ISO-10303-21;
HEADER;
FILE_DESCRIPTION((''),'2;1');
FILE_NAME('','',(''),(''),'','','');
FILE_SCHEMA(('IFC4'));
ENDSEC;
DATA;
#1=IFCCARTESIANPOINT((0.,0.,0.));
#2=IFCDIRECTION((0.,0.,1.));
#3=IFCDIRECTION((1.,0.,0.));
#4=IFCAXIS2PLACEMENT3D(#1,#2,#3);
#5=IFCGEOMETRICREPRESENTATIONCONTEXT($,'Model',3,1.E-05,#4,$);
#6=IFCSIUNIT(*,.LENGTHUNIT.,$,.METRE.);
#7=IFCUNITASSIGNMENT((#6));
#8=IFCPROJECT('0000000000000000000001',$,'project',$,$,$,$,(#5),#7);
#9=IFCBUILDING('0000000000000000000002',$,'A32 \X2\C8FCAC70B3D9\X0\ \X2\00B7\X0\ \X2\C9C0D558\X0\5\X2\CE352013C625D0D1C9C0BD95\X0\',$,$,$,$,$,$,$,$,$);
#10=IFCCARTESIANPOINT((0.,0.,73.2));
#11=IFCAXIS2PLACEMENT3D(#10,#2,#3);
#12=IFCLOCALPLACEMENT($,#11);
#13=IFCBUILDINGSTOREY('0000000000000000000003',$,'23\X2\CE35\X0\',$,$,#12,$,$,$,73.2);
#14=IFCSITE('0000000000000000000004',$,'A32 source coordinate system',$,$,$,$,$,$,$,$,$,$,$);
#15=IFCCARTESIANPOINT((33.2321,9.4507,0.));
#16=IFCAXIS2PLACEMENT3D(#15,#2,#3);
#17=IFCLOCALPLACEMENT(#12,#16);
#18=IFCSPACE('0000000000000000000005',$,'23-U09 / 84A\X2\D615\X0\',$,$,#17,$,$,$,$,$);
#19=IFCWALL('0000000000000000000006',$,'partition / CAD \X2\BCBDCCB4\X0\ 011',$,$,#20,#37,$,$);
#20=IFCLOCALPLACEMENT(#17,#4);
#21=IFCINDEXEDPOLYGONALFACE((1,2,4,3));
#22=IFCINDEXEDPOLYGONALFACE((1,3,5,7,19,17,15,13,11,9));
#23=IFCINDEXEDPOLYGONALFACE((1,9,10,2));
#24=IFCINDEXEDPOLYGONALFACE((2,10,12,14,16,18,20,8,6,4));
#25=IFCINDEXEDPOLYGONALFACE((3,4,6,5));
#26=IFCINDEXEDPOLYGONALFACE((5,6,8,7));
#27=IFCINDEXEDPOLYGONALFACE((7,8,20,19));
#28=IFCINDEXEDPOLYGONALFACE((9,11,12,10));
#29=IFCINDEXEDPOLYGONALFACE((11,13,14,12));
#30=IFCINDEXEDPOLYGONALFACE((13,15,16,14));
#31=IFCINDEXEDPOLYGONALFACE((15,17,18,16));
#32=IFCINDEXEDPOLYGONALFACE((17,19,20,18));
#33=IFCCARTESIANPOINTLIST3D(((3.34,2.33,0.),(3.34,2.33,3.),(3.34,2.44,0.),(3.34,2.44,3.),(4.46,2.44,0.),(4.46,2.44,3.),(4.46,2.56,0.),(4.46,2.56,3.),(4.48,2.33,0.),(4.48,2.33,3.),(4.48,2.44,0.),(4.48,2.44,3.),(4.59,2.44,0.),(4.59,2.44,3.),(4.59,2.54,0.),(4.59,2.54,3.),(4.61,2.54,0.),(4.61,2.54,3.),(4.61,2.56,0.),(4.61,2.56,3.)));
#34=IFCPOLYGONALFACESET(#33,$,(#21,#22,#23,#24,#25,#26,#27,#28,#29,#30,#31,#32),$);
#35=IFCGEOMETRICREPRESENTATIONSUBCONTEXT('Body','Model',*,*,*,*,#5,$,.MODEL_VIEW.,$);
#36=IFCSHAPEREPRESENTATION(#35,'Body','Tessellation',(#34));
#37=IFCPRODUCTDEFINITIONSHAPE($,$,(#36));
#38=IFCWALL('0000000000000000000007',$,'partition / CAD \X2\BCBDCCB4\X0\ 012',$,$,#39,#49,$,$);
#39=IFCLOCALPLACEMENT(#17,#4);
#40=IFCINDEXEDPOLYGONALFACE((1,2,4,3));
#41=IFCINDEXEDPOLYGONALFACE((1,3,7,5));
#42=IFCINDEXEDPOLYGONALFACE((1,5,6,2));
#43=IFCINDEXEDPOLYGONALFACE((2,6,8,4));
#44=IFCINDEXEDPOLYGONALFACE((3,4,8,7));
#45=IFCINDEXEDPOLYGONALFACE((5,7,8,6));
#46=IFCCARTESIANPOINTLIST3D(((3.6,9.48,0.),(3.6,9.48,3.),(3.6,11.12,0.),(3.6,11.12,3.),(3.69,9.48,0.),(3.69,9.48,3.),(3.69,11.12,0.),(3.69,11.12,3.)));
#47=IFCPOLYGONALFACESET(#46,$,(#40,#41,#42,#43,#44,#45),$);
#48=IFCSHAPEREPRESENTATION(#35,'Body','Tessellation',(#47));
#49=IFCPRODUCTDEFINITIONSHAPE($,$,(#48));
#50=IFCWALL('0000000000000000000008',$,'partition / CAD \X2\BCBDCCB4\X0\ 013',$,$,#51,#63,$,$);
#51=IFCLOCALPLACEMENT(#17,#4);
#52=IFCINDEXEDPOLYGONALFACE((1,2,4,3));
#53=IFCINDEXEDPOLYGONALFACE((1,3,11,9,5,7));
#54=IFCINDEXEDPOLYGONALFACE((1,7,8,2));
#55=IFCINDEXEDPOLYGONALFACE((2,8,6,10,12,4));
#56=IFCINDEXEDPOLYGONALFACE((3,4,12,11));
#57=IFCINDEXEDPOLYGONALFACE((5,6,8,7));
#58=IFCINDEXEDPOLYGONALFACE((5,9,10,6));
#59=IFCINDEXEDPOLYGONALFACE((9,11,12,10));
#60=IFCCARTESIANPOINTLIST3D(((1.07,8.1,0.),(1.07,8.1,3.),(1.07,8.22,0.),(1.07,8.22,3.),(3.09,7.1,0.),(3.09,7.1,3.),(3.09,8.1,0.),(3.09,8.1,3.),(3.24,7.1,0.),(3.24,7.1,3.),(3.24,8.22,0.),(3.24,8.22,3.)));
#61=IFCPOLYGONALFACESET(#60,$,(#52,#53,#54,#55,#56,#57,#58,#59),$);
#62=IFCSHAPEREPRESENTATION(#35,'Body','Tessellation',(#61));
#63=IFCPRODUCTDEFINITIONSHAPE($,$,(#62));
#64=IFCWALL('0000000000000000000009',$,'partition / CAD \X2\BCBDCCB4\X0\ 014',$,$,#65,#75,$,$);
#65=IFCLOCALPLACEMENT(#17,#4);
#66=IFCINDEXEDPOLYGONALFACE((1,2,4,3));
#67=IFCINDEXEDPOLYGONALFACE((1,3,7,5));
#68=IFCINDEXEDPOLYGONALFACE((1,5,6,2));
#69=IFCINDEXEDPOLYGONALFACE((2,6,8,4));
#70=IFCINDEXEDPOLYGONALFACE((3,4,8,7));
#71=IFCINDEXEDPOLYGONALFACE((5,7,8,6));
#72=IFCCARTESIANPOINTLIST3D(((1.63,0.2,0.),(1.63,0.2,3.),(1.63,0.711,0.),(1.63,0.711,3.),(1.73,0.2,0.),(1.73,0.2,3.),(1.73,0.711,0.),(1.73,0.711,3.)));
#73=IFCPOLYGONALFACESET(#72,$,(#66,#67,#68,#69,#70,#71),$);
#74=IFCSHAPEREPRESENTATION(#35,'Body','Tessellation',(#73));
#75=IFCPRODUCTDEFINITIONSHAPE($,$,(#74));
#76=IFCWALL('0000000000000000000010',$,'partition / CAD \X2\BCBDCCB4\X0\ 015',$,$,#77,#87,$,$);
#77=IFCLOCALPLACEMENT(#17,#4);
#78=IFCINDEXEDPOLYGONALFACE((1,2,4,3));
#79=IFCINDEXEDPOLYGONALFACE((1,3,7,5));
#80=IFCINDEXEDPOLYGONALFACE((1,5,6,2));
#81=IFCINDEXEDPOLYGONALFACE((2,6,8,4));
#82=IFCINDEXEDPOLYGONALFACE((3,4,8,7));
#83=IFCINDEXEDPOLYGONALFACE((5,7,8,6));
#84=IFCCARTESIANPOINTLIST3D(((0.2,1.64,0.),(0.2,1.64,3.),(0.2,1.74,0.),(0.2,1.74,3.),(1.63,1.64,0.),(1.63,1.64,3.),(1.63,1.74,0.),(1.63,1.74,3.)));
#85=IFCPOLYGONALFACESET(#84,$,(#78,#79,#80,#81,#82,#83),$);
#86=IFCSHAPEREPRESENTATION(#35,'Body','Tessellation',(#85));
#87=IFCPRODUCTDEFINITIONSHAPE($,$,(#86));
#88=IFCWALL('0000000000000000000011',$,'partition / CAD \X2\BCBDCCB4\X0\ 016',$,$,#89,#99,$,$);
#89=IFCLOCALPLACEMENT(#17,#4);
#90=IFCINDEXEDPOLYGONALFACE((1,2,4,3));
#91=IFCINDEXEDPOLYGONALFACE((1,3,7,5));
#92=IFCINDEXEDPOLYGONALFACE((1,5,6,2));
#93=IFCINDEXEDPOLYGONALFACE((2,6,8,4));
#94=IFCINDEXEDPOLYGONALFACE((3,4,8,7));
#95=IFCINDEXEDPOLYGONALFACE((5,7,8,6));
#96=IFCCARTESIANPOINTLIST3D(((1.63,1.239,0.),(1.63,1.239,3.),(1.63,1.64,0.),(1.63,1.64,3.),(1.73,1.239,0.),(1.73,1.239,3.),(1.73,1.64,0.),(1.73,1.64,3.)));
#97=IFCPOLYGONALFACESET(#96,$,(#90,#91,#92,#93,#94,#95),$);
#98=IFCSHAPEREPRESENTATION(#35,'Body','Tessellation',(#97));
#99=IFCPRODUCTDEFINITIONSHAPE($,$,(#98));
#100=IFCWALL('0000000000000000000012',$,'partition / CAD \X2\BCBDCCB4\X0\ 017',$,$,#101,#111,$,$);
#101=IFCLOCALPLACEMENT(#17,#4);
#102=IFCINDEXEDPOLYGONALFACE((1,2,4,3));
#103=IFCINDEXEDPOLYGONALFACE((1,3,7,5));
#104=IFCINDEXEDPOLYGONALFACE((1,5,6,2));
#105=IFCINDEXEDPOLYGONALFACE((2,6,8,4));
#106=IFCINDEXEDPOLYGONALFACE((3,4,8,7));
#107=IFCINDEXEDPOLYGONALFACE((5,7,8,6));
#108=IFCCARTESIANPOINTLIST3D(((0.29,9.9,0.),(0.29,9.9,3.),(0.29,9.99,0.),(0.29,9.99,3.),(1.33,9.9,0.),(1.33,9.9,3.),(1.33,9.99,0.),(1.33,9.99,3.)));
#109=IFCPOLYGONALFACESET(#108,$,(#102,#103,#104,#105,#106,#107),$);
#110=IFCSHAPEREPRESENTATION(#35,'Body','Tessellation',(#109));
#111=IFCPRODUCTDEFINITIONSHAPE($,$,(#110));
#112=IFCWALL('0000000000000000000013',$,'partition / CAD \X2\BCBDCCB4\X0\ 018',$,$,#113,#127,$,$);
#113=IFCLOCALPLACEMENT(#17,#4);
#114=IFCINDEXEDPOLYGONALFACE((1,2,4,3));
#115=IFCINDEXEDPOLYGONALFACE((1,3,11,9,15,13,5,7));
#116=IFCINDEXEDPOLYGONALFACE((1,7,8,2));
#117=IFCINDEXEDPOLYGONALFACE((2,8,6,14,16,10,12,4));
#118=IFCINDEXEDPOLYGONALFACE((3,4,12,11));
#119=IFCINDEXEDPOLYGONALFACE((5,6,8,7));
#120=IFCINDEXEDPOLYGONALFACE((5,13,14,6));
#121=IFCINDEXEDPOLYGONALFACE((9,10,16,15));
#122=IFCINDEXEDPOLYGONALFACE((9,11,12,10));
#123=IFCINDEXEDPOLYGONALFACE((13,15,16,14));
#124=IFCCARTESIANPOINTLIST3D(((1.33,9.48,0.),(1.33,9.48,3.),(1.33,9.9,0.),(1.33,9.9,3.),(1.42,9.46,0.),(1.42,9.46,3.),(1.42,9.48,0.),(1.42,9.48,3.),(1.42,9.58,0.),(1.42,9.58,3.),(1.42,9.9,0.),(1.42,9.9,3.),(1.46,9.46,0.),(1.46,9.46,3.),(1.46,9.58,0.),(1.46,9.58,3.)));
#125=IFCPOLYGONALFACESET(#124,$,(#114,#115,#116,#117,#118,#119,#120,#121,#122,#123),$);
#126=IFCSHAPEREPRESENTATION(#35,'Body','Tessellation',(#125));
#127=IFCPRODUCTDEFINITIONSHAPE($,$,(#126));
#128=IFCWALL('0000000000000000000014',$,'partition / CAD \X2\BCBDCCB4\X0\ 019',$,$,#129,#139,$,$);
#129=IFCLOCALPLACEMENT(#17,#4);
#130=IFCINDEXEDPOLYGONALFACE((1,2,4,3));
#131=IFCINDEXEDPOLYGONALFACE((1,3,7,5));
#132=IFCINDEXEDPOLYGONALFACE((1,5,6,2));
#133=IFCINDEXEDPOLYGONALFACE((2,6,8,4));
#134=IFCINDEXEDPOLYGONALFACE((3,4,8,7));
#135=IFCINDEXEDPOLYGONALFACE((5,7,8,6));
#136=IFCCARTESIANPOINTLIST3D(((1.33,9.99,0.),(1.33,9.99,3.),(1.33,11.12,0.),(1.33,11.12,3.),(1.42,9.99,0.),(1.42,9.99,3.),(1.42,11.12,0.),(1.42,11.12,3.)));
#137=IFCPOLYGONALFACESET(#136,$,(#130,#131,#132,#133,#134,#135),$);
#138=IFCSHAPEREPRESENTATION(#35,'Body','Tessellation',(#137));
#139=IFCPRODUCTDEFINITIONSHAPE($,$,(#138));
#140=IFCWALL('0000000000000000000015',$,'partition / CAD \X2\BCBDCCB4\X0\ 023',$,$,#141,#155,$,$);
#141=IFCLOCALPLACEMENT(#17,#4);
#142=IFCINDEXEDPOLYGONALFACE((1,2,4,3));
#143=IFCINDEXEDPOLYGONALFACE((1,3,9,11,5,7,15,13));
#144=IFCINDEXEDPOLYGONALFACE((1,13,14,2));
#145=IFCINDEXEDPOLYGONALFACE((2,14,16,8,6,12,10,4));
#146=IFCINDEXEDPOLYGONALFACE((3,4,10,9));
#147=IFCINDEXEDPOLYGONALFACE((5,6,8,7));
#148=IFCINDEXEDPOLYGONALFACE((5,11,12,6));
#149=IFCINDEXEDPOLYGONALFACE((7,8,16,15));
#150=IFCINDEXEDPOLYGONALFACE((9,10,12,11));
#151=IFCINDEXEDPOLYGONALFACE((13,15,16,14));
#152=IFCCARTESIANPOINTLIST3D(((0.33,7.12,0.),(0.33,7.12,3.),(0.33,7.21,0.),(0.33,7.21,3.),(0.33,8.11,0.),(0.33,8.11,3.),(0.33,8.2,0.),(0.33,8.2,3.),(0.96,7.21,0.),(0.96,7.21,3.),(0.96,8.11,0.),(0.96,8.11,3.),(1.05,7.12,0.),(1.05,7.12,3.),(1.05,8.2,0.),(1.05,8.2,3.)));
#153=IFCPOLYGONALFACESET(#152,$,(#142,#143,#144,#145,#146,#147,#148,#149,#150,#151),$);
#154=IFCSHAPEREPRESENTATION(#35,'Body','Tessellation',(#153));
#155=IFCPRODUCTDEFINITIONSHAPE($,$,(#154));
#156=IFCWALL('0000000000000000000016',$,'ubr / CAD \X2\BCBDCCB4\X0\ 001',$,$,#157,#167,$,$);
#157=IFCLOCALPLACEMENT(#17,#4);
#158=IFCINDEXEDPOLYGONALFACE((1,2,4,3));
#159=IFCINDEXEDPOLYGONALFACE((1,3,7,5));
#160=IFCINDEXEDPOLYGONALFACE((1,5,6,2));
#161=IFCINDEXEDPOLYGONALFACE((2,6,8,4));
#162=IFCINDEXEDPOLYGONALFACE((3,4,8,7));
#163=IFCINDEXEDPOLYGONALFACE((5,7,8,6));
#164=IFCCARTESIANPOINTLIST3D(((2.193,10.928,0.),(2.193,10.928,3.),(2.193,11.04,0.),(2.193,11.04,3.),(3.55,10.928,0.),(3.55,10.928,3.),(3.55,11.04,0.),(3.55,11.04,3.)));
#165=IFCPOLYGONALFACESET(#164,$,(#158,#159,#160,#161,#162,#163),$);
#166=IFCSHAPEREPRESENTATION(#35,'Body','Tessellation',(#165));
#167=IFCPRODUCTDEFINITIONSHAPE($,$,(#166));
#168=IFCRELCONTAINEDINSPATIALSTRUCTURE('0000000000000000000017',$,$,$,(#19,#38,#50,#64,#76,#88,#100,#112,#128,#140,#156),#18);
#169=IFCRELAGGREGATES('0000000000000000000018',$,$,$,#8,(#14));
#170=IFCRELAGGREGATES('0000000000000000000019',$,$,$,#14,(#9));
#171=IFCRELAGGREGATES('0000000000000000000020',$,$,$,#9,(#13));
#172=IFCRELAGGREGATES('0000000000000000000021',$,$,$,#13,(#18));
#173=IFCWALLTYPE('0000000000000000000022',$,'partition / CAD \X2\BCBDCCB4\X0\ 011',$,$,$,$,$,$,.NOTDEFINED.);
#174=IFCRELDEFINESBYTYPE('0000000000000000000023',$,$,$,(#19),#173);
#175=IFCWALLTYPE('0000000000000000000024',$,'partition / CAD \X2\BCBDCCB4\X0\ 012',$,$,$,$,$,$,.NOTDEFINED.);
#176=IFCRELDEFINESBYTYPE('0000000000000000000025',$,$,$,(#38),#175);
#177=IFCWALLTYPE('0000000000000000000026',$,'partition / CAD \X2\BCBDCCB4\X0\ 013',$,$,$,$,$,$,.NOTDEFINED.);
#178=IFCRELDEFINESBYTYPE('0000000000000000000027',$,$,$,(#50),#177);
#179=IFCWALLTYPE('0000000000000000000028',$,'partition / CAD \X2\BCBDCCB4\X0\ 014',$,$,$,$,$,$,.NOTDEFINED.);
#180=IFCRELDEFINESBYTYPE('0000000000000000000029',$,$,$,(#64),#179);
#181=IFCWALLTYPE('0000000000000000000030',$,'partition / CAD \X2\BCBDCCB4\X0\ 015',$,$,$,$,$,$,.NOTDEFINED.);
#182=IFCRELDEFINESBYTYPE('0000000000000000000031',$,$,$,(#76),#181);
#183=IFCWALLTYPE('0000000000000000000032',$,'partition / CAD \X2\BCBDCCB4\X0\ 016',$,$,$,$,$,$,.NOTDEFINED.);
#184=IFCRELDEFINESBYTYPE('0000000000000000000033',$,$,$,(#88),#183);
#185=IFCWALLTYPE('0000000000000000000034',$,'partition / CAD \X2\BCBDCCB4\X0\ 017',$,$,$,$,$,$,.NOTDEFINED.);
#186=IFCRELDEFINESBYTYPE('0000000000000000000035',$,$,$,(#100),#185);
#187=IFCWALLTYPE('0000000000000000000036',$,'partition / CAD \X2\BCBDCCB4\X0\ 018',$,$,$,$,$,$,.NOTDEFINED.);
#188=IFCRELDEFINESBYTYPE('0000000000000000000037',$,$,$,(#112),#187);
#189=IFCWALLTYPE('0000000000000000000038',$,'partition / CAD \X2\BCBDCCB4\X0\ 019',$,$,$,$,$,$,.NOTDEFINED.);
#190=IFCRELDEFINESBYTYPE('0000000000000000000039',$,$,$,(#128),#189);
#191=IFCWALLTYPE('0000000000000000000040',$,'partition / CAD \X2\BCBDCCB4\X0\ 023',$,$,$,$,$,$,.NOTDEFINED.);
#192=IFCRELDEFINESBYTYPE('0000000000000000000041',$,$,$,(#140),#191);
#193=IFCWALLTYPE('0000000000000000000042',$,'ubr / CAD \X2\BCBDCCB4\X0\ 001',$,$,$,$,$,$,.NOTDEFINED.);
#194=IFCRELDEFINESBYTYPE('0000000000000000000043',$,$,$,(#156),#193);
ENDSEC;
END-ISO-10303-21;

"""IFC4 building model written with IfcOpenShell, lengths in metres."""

from ifc_helpers import new_model, si_unit, frame, origin, origin_with_axes, place, context, subcontext, project, spatial, polyline, outline, extrude, source, transform, mapped, type_object, type_shapes, element, save


model = new_model("IFC4")

# Units and contexts
model_context = context("Model", 3, precision=1e-05, world=origin_with_axes())
body_context = subcontext(model_context, "Body", "Model", "MODEL_VIEW")
ifc_project = project(units=[si_unit("LENGTHUNIT", "METRE")], contexts=[model_context])

# Site, building, storey, space
site = spatial("IfcSite", under=ifc_project, Name="A32 source coordinate system")
building = spatial("IfcBuilding", under=site, Name="A32 주거동 · 지하5층–옥탑지붕")
storey_placement = place(None, frame((0.0, 0.0, 73.2), z_axis=(0.0, 0.0, 1.0), x_axis=(1.0, 0.0, 0.0)))
storey = spatial("IfcBuildingStorey", under=building, at=storey_placement, Name="23층", Elevation=73.2)
space_placement = place(storey_placement, frame((33.2321, 9.4507, 0.0), z_axis=(0.0, 0.0, 1.0), x_axis=(1.0, 0.0, 0.0)))
space = spatial("IfcSpace", under=storey, at=space_placement, Name="23-U09 / 84A형")

# Walls
wall_type_1 = type_object("IfcWallType", Name="partition / CAD 벽체 011", PredefinedType="NOTDEFINED")
shared_shape_1 = source(origin(), body_context, "Body", "SweptSolid", [
    extrude(outline(polyline([(3.34, 2.33), (3.34, 2.44), (4.46, 2.44), (4.46, 2.56), (4.61, 2.56), (4.61, 2.54), (4.59, 2.54), (4.59, 2.44), (4.48, 2.44), (4.48, 2.33), (3.34, 2.33)])), origin(), (0.0, 0.0, 1.0), 3.0),
])
type_shapes(wall_type_1, [shared_shape_1])
wall_1_placement = place(space_placement, origin_with_axes())
element("IfcWall", 1, at=wall_1_placement, inside=space, type_object=wall_type_1, Name="partition / CAD 벽체 011", context=body_context, shape_type="MappedRepresentation", body=[
    mapped(shared_shape_1, transform((0.0, 0.0, 0.0), scale=1.0)),
])
wall_type_2 = type_object("IfcWallType", Name="partition / CAD 벽체 012", PredefinedType="NOTDEFINED")
shared_shape_2 = source(origin(), body_context, "Body", "SweptSolid", [
    extrude(outline(polyline([(3.6, 11.12), (3.69, 11.12), (3.69, 9.48), (3.6, 9.48), (3.6, 11.12)])), origin(), (0.0, 0.0, 1.0), 3.0),
])
type_shapes(wall_type_2, [shared_shape_2])
wall_2_placement = place(space_placement, origin_with_axes())
element("IfcWall", 2, at=wall_2_placement, inside=space, type_object=wall_type_2, Name="partition / CAD 벽체 012", context=body_context, shape_type="MappedRepresentation", body=[
    mapped(shared_shape_2, transform((0.0, 0.0, 0.0), scale=1.0)),
])
wall_type_3 = type_object("IfcWallType", Name="partition / CAD 벽체 013", PredefinedType="NOTDEFINED")
shared_shape_3 = source(origin(), body_context, "Body", "SweptSolid", [
    extrude(outline(polyline([(3.09, 8.1), (1.07, 8.1), (1.07, 8.22), (3.24, 8.22), (3.24, 7.1), (3.09, 7.1), (3.09, 8.1)])), origin(), (0.0, 0.0, 1.0), 3.0),
])
type_shapes(wall_type_3, [shared_shape_3])
wall_3_placement = place(space_placement, origin_with_axes())
element("IfcWall", 3, at=wall_3_placement, inside=space, type_object=wall_type_3, Name="partition / CAD 벽체 013", context=body_context, shape_type="MappedRepresentation", body=[
    mapped(shared_shape_3, transform((0.0, 0.0, 0.0), scale=1.0)),
])
wall_type_4 = type_object("IfcWallType", Name="partition / CAD 벽체 014", PredefinedType="NOTDEFINED")
shared_shape_4 = source(origin(), body_context, "Body", "SweptSolid", [
    extrude(outline(polyline([(1.73, 0.2), (1.63, 0.2), (1.63, 0.711), (1.73, 0.711), (1.73, 0.2)])), origin(), (0.0, 0.0, 1.0), 3.0),
])
type_shapes(wall_type_4, [shared_shape_4])
wall_4_placement = place(space_placement, origin_with_axes())
element("IfcWall", 4, at=wall_4_placement, inside=space, type_object=wall_type_4, Name="partition / CAD 벽체 014", context=body_context, shape_type="MappedRepresentation", body=[
    mapped(shared_shape_4, transform((0.0, 0.0, 0.0), scale=1.0)),
])
wall_type_5 = type_object("IfcWallType", Name="partition / CAD 벽체 015", PredefinedType="NOTDEFINED")
shared_shape_5 = source(origin(), body_context, "Body", "SweptSolid", [
    extrude(outline(polyline([(1.63, 1.74), (1.63, 1.64), (0.2, 1.64), (0.2, 1.74), (1.63, 1.74)])), origin(), (0.0, 0.0, 1.0), 3.0),
])
type_shapes(wall_type_5, [shared_shape_5])
wall_5_placement = place(space_placement, origin_with_axes())
element("IfcWall", 5, at=wall_5_placement, inside=space, type_object=wall_type_5, Name="partition / CAD 벽체 015", context=body_context, shape_type="MappedRepresentation", body=[
    mapped(shared_shape_5, transform((0.0, 0.0, 0.0), scale=1.0)),
])
wall_type_6 = type_object("IfcWallType", Name="partition / CAD 벽체 016", PredefinedType="NOTDEFINED")
shared_shape_6 = source(origin(), body_context, "Body", "SweptSolid", [
    extrude(outline(polyline([(1.73, 1.239), (1.63, 1.239), (1.63, 1.64), (1.73, 1.64), (1.73, 1.239)])), origin(), (0.0, 0.0, 1.0), 3.0),
])
type_shapes(wall_type_6, [shared_shape_6])
wall_6_placement = place(space_placement, origin_with_axes())
element("IfcWall", 6, at=wall_6_placement, inside=space, type_object=wall_type_6, Name="partition / CAD 벽체 016", context=body_context, shape_type="MappedRepresentation", body=[
    mapped(shared_shape_6, transform((0.0, 0.0, 0.0), scale=1.0)),
])
wall_type_7 = type_object("IfcWallType", Name="partition / CAD 벽체 017", PredefinedType="NOTDEFINED")
shared_shape_7 = source(origin(), body_context, "Body", "SweptSolid", [
    extrude(outline(polyline([(1.33, 9.99), (1.33, 9.9), (0.29, 9.9), (0.29, 9.99), (1.33, 9.99)])), origin(), (0.0, 0.0, 1.0), 3.0),
])
type_shapes(wall_type_7, [shared_shape_7])
wall_7_placement = place(space_placement, origin_with_axes())
element("IfcWall", 7, at=wall_7_placement, inside=space, type_object=wall_type_7, Name="partition / CAD 벽체 017", context=body_context, shape_type="MappedRepresentation", body=[
    mapped(shared_shape_7, transform((0.0, 0.0, 0.0), scale=1.0)),
])
wall_type_8 = type_object("IfcWallType", Name="partition / CAD 벽체 018", PredefinedType="NOTDEFINED")
shared_shape_8 = source(origin(), body_context, "Body", "SweptSolid", [
    extrude(outline(polyline([(1.42, 9.58), (1.46, 9.58), (1.46, 9.46), (1.42, 9.46), (1.42, 9.48), (1.33, 9.48), (1.33, 9.9), (1.42, 9.9), (1.42, 9.58)])), origin(), (0.0, 0.0, 1.0), 3.0),
])
type_shapes(wall_type_8, [shared_shape_8])
wall_8_placement = place(space_placement, origin_with_axes())
element("IfcWall", 8, at=wall_8_placement, inside=space, type_object=wall_type_8, Name="partition / CAD 벽체 018", context=body_context, shape_type="MappedRepresentation", body=[
    mapped(shared_shape_8, transform((0.0, 0.0, 0.0), scale=1.0)),
])
wall_type_9 = type_object("IfcWallType", Name="partition / CAD 벽체 019", PredefinedType="NOTDEFINED")
shared_shape_9 = source(origin(), body_context, "Body", "SweptSolid", [
    extrude(outline(polyline([(1.33, 11.12), (1.42, 11.12), (1.42, 9.99), (1.33, 9.99), (1.33, 11.12)])), origin(), (0.0, 0.0, 1.0), 3.0),
])
type_shapes(wall_type_9, [shared_shape_9])
wall_9_placement = place(space_placement, origin_with_axes())
element("IfcWall", 9, at=wall_9_placement, inside=space, type_object=wall_type_9, Name="partition / CAD 벽체 019", context=body_context, shape_type="MappedRepresentation", body=[
    mapped(shared_shape_9, transform((0.0, 0.0, 0.0), scale=1.0)),
])
wall_type_10 = type_object("IfcWallType", Name="partition / CAD 벽체 023", PredefinedType="NOTDEFINED")
shared_shape_10 = source(origin(), body_context, "Body", "SweptSolid", [
    extrude(outline(polyline([(0.96, 8.11), (0.33, 8.11), (0.33, 8.2), (1.05, 8.2), (1.05, 7.12), (0.33, 7.12), (0.33, 7.21), (0.96, 7.21), (0.96, 8.11)])), origin(), (0.0, 0.0, 1.0), 3.0),
])
type_shapes(wall_type_10, [shared_shape_10])
wall_10_placement = place(space_placement, origin_with_axes())
element("IfcWall", 10, at=wall_10_placement, inside=space, type_object=wall_type_10, Name="partition / CAD 벽체 023", context=body_context, shape_type="MappedRepresentation", body=[
    mapped(shared_shape_10, transform((0.0, 0.0, 0.0), scale=1.0)),
])
wall_type_11 = type_object("IfcWallType", Name="ubr / CAD 벽체 001", PredefinedType="NOTDEFINED")
shared_shape_11 = source(origin(), body_context, "Body", "SweptSolid", [
    extrude(outline(polyline([(3.55, 11.04), (3.55, 10.928), (2.193, 10.928), (2.193, 11.04), (3.55, 11.04)])), origin(), (0.0, 0.0, 1.0), 3.0),
])
type_shapes(wall_type_11, [shared_shape_11])
wall_11_placement = place(space_placement, origin_with_axes())
element("IfcWall", 11, at=wall_11_placement, inside=space, type_object=wall_type_11, Name="ubr / CAD 벽체 001", context=body_context, shape_type="MappedRepresentation", body=[
    mapped(shared_shape_11, transform((0.0, 0.0, 0.0), scale=1.0)),
])

save(model, "model.ifc")
